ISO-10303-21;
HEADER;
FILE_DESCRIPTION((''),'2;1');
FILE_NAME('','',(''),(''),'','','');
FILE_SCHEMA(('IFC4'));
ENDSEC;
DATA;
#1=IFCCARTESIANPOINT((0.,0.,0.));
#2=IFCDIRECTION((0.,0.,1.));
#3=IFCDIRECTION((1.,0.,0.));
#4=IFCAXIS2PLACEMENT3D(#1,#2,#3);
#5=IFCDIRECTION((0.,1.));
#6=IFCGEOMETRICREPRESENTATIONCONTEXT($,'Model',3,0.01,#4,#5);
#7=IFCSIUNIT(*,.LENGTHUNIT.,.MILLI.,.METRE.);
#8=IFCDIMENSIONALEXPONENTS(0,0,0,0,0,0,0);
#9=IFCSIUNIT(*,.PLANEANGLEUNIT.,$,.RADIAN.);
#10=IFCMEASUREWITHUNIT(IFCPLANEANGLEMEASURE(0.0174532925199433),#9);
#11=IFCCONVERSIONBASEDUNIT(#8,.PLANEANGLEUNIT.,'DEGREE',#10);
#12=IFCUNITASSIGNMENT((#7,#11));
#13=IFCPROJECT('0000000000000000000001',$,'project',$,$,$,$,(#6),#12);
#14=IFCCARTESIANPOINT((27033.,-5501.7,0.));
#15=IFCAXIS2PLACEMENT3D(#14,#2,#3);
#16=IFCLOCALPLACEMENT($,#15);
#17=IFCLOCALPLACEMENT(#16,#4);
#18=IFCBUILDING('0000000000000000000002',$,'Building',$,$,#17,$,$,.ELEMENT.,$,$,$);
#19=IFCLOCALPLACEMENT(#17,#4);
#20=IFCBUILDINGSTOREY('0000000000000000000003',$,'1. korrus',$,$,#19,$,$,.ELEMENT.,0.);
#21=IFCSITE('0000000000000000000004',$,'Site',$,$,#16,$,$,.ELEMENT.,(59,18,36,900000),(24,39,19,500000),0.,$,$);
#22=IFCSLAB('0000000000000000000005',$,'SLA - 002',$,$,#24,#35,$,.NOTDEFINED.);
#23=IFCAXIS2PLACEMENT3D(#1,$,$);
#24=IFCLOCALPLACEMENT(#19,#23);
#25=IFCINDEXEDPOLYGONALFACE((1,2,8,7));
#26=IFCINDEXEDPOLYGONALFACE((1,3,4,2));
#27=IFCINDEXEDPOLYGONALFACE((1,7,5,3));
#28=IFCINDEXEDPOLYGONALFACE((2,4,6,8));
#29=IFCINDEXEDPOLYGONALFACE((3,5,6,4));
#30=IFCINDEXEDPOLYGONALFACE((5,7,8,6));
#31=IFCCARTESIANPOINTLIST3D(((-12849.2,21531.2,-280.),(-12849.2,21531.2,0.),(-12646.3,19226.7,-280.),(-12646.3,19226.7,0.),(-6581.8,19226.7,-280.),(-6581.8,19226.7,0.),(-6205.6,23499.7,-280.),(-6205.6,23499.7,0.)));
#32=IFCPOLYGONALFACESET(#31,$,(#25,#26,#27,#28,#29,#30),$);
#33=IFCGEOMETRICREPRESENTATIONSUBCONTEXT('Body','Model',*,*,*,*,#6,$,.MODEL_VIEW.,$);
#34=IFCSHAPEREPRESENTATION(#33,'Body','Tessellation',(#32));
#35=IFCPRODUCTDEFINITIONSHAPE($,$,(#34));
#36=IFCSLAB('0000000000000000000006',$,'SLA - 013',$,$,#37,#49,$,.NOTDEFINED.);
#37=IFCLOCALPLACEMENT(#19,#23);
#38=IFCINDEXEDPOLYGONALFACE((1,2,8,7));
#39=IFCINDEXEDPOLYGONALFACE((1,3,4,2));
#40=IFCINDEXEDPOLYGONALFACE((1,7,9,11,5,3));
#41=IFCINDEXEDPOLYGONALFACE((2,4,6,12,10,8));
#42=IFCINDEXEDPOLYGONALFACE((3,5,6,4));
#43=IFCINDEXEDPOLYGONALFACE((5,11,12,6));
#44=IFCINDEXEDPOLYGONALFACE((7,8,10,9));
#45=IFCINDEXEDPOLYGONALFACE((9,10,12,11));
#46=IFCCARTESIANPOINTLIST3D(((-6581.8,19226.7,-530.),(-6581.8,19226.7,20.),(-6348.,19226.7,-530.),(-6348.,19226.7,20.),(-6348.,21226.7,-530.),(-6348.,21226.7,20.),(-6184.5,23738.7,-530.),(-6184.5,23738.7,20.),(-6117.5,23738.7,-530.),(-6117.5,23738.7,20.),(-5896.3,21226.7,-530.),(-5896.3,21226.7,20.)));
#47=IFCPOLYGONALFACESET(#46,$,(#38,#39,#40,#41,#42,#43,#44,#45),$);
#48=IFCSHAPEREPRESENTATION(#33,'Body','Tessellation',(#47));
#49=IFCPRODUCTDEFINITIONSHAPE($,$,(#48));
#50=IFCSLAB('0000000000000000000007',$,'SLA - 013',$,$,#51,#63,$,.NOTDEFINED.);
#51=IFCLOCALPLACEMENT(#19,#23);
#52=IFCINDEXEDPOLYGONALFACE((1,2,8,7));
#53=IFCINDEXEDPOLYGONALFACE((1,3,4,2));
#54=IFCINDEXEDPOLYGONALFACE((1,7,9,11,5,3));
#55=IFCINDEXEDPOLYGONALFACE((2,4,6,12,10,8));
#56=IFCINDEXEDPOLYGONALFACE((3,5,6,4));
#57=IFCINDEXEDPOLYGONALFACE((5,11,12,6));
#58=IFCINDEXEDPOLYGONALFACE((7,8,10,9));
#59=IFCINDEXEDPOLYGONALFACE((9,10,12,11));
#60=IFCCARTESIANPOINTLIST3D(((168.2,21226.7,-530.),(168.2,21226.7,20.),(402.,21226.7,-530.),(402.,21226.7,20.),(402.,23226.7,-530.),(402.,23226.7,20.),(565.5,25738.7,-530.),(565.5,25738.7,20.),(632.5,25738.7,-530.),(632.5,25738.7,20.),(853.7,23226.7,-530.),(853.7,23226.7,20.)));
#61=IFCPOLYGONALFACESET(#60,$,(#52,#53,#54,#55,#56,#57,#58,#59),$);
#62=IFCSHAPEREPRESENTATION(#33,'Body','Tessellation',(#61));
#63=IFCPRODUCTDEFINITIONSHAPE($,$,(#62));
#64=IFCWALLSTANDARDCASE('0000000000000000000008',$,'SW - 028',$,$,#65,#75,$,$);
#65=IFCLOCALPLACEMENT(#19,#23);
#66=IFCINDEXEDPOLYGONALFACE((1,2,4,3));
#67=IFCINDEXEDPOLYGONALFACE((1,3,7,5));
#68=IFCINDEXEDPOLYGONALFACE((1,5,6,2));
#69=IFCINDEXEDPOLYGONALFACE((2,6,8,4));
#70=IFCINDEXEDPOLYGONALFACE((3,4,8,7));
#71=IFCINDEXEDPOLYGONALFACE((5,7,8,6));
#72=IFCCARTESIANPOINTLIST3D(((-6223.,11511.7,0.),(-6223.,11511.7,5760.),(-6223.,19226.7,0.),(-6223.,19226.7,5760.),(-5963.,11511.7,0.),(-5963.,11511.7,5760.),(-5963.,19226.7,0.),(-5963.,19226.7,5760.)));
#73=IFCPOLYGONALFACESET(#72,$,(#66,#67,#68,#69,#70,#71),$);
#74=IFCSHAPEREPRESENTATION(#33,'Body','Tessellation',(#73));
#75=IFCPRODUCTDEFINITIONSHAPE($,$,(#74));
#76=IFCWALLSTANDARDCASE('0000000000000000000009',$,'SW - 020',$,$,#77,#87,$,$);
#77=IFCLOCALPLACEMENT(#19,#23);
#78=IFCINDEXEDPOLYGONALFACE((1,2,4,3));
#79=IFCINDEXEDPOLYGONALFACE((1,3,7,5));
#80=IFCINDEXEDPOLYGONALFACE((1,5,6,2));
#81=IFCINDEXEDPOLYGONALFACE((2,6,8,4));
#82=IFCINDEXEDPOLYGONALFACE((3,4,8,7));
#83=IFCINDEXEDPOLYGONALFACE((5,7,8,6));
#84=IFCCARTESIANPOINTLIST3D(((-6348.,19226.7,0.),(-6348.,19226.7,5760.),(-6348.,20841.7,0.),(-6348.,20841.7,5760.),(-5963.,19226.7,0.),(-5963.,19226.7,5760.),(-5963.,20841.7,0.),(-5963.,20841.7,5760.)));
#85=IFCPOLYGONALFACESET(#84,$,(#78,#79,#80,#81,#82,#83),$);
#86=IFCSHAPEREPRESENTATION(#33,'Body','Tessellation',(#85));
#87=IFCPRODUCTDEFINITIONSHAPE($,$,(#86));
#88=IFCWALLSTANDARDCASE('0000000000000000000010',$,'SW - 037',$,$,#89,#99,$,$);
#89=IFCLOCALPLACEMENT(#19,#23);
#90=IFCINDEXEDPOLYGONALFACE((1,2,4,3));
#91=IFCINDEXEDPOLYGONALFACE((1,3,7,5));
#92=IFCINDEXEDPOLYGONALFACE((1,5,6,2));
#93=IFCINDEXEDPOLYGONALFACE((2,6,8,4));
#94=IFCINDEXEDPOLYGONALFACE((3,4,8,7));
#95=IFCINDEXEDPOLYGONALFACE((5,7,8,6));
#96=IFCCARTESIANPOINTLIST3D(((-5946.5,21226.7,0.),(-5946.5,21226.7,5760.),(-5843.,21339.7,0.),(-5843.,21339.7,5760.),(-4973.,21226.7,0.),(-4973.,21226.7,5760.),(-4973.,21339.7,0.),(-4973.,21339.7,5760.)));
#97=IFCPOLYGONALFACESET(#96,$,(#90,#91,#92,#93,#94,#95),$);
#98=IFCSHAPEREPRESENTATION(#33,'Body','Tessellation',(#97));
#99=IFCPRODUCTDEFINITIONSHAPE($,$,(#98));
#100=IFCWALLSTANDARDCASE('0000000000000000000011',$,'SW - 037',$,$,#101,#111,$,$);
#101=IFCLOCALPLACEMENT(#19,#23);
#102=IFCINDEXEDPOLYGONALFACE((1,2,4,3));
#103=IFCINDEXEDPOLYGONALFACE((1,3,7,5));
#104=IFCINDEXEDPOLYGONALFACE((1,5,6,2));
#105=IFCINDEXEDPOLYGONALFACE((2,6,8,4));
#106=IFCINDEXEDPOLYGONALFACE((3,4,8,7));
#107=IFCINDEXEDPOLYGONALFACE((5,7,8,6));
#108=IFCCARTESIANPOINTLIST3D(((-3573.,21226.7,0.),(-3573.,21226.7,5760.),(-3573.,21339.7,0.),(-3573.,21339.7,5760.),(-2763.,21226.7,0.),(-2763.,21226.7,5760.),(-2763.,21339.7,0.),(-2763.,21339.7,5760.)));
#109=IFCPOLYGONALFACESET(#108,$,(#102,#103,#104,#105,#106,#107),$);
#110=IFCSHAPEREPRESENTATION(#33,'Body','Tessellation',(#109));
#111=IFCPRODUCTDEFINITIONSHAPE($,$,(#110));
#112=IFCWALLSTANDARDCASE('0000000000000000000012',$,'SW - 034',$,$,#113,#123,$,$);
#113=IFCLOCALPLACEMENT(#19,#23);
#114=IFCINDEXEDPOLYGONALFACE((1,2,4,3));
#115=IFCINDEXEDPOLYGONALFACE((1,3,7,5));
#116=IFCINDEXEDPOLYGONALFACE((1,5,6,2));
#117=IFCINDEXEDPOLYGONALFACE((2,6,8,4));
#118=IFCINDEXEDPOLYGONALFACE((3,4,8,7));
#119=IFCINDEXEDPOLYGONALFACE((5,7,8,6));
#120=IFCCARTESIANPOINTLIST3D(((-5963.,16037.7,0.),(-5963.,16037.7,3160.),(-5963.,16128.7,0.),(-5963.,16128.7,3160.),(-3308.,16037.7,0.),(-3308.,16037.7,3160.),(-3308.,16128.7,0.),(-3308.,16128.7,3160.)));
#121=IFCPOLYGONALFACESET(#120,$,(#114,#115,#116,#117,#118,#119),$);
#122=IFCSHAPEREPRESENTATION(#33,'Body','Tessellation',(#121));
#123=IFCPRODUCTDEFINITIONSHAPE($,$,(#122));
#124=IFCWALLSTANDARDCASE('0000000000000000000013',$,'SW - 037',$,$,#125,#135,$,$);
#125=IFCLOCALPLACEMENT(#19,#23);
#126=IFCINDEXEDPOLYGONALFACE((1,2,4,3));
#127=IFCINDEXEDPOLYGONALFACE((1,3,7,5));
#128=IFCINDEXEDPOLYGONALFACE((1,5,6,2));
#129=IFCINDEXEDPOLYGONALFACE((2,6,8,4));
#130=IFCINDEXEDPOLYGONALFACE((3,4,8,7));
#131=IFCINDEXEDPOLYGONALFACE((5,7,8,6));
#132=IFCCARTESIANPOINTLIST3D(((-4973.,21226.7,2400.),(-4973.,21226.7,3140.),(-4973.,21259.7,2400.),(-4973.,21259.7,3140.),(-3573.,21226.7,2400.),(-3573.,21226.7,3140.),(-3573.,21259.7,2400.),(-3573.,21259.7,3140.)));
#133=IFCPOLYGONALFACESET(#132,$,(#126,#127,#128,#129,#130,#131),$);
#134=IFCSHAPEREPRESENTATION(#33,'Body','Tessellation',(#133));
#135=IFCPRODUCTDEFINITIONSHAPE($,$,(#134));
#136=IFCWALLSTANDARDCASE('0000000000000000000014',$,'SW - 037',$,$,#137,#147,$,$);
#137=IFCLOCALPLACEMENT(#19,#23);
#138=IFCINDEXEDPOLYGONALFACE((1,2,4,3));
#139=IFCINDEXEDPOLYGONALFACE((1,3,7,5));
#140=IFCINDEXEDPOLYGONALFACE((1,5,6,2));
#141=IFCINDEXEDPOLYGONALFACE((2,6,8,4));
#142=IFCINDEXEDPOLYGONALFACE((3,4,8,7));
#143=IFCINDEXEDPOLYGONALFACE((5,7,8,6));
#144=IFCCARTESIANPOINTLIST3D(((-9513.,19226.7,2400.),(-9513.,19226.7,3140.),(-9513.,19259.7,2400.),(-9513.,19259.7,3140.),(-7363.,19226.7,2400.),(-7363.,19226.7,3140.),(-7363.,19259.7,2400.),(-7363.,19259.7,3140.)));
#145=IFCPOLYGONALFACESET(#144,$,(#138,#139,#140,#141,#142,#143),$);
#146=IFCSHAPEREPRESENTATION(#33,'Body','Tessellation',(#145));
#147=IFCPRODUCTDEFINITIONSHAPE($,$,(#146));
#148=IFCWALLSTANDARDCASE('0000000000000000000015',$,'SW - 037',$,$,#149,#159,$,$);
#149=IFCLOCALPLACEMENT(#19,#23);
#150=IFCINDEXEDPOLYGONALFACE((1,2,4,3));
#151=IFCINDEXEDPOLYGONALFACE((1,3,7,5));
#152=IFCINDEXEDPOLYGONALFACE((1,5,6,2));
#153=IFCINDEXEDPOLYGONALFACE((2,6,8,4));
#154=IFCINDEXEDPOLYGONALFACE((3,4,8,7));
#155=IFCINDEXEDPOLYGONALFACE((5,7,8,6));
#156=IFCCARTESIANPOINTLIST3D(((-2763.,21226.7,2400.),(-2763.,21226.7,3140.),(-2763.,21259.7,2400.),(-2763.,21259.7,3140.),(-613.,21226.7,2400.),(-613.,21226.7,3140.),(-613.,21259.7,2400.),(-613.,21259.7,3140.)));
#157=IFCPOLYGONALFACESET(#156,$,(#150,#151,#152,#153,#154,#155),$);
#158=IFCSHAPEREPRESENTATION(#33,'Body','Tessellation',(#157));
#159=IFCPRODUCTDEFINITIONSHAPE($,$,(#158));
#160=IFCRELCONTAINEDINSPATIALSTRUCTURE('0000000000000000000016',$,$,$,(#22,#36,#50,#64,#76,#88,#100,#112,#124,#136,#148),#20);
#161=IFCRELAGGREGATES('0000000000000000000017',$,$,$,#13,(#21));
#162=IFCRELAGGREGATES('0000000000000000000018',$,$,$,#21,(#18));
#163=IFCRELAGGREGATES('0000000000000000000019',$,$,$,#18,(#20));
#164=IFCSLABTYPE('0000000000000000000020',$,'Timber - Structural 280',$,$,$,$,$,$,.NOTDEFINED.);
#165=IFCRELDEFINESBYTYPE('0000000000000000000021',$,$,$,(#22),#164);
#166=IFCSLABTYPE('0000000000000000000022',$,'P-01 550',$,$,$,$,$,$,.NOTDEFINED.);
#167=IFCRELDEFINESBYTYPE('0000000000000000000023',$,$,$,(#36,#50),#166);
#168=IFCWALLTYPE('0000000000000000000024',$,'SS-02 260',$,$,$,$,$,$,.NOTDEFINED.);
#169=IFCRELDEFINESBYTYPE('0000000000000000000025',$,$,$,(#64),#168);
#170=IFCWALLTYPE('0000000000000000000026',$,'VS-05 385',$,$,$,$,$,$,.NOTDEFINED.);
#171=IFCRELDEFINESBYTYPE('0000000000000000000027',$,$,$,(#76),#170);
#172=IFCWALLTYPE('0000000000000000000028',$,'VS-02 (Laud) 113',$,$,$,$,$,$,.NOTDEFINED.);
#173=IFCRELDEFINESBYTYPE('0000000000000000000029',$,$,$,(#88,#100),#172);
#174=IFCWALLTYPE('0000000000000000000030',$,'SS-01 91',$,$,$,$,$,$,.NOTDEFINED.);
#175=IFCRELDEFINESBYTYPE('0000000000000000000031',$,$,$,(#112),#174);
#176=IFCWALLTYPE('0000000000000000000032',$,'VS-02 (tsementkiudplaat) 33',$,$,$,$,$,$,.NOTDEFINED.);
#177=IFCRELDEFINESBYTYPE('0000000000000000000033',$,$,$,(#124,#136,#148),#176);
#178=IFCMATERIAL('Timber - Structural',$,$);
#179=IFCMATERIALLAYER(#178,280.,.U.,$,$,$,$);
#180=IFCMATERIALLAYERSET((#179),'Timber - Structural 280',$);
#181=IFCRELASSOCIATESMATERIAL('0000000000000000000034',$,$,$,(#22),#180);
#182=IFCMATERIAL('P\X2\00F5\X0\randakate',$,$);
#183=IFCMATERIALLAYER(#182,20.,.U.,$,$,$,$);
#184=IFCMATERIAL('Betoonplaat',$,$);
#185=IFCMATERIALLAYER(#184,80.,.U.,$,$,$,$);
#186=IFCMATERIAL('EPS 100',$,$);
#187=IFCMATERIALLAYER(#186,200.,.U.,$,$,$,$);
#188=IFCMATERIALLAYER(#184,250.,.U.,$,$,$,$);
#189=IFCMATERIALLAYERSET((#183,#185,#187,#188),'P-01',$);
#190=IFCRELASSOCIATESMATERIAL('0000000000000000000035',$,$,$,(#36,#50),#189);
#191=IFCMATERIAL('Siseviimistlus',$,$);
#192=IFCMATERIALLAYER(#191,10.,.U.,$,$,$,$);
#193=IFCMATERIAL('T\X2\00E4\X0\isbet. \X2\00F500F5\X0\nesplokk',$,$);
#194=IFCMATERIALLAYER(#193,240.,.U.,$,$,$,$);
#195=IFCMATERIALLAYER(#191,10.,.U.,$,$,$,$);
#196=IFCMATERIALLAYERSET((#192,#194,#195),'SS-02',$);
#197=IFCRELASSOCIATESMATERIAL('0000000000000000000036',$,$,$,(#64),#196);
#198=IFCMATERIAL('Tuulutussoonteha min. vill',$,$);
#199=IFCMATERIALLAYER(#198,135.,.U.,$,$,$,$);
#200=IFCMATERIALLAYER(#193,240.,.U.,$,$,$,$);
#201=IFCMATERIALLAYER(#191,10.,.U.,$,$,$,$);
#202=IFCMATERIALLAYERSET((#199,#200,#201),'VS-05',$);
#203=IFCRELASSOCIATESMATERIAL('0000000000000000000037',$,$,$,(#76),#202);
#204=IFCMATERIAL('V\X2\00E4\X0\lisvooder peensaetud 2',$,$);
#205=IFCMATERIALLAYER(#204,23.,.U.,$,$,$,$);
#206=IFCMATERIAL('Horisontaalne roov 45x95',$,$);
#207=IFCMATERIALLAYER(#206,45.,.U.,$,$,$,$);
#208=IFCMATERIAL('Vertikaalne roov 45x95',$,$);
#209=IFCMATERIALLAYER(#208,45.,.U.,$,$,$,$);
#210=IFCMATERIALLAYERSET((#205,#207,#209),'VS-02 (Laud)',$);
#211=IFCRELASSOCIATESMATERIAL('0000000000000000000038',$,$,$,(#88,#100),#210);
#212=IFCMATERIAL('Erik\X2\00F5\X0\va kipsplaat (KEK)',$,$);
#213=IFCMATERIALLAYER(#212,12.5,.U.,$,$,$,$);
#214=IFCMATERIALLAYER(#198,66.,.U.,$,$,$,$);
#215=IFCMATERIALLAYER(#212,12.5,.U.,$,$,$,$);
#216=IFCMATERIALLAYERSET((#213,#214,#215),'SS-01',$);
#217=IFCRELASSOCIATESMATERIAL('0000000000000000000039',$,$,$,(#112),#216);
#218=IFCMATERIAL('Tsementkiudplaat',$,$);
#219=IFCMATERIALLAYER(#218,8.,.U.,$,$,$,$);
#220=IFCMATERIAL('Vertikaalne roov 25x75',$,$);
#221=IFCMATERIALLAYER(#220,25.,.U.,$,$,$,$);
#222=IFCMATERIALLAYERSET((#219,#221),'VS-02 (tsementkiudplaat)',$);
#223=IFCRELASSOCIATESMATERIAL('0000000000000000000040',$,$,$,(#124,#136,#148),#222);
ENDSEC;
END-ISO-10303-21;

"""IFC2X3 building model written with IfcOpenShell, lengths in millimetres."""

from ifc_helpers import new_model, entity, si_unit, converted_unit, direction, frame, origin_with_axes, place, context, subcontext, project, spatial, polyline, outline, extrude, material, layer, layer_set, layer_usage, type_object, element, save


model = new_model("IFC2X3")

# Units and contexts
model_context = context("Model", 3, precision=0.01, world=origin_with_axes(), true_north=direction((0.0, 1.0)))
body_context = subcontext(model_context, "Body", "Model", "MODEL_VIEW")
ifc_project = project(units=[si_unit("LENGTHUNIT", "METRE", prefix="MILLI"), converted_unit("PLANEANGLEUNIT", "DEGREE", entity("IfcPlaneAngleMeasure", 0.0174532925199433), si_unit("PLANEANGLEUNIT", "RADIAN"), dimensions=[0, 0, 0, 0, 0, 0, 0])], contexts=[model_context])

# Site, building, storey
site_placement = place(None, frame((27033.0, -5501.7, 0.0), z_axis=(0.0, 0.0, 1.0), x_axis=(1.0, 0.0, 0.0)))
site = spatial("IfcSite", under=ifc_project, at=site_placement, Name="Site", CompositionType="ELEMENT", RefLatitude=(59, 18, 36, 900000), RefLongitude=(24, 39, 19, 500000), RefElevation=0.0)
building_placement = place(site_placement, origin_with_axes())
building = spatial("IfcBuilding", under=site, at=building_placement, Name="Building", CompositionType="ELEMENT")
storey_placement = place(building_placement, origin_with_axes())
storey = spatial("IfcBuildingStorey", under=building, at=storey_placement, Name="1. korrus", CompositionType="ELEMENT", Elevation=0.0)

# Slabs
ifc_material_1 = material(Name="Timber - Structural")
ifc_layer_1 = layer(ifc_material_1, 280.0, ventilated="UNKNOWN")
ifc_layer_set_1 = layer_set([ifc_layer_1], Name="Timber - Structural 280")
ifc_layer_usage_1 = layer_usage(ifc_layer_set_1, "AXIS3", "NEGATIVE", 280.0)
slab_type_1 = type_object("IfcSlabType", Name="Timber - Structural 280", PredefinedType="NOTDEFINED")
slab_1_placement = place(storey_placement, frame((-6205.6, 23499.7, 0.0), z_axis=(0.0, 0.0, 1.0), x_axis=(1.0, 0.0, 0.0)))
element("IfcSlab", 1, at=slab_1_placement, inside=storey, type_object=slab_type_1, material=ifc_layer_usage_1, Name="SLA - 002", PredefinedType="NOTDEFINED", context=body_context, shape_type="SweptSolid", body=[
    extrude(outline(polyline([(0.0, 0.0), (-6643.7, -1968.5), (-6440.8, -4273.0), (-376.2, -4273.0), (0.0, 0.0)])), frame((0.0, 0.0, -280.0), z_axis=(0.0, 0.0, 1.0), x_axis=(1.0, 0.0, 0.0)), (0.0, 0.0, 1.0), 280.0),
])
ifc_material_2 = material(Name="Põrandakate")
ifc_layer_2 = layer(ifc_material_2, 20.0, ventilated="UNKNOWN")
ifc_material_3 = material(Name="Betoonplaat")
ifc_layer_3 = layer(ifc_material_3, 80.0, ventilated="UNKNOWN")
ifc_material_4 = material(Name="EPS 100")
ifc_layer_4 = layer(ifc_material_4, 200.0, ventilated="UNKNOWN")
ifc_layer_5 = layer(ifc_material_3, 250.0, ventilated="UNKNOWN")
ifc_layer_set_2 = layer_set([ifc_layer_2, ifc_layer_3, ifc_layer_4, ifc_layer_5], Name="P-01")
ifc_layer_usage_2 = layer_usage(ifc_layer_set_2, "AXIS3", "NEGATIVE", 550.0)
slab_type_2 = type_object("IfcSlabType", Name="P-01 550", PredefinedType="NOTDEFINED")
slab_2_placement = place(storey_placement, frame((-6581.8, 19226.7, 0.0), z_axis=(0.0, 0.0, 1.0), x_axis=(1.0, 0.0, 0.0)))
element("IfcSlab", 2, at=slab_2_placement, inside=storey, type_object=slab_type_2, material=ifc_layer_usage_2, Name="SLA - 013", PredefinedType="NOTDEFINED", context=body_context, shape_type="SweptSolid", body=[
    extrude(outline(polyline([(0.0, 0.0), (233.8, 0.0), (233.8, 2000.0), (685.5, 2000.0), (464.3, 4512.0), (397.3, 4512.0), (0.0, 0.0)])), frame((0.0, 0.0, -530.0), z_axis=(0.0, 0.0, 1.0), x_axis=(1.0, 0.0, 0.0)), (0.0, 0.0, 1.0), 550.0),
])
ifc_layer_usage_3 = layer_usage(ifc_layer_set_2, "AXIS3", "NEGATIVE", 550.0)
slab_3_placement = place(storey_placement, frame((168.2, 21226.7, 0.0), z_axis=(0.0, 0.0, 1.0), x_axis=(1.0, 0.0, 0.0)))
element("IfcSlab", 3, at=slab_3_placement, inside=storey, type_object=slab_type_2, material=ifc_layer_usage_3, Name="SLA - 013", PredefinedType="NOTDEFINED", context=body_context, shape_type="SweptSolid", body=[
    extrude(outline(polyline([(0.0, 0.0), (233.8, 0.0), (233.8, 2000.0), (685.5, 2000.0), (464.3, 4512.0), (397.3, 4512.0), (0.0, 0.0)])), frame((0.0, 0.0, -530.0), z_axis=(0.0, 0.0, 1.0), x_axis=(1.0, 0.0, 0.0)), (0.0, 0.0, 1.0), 550.0),
])

# Wall
ifc_material_5 = material(Name="Siseviimistlus")
ifc_layer_6 = layer(ifc_material_5, 10.0, ventilated="UNKNOWN")
ifc_material_6 = material(Name="Täisbet. õõnesplokk")
ifc_layer_7 = layer(ifc_material_6, 240.0, ventilated="UNKNOWN")
ifc_layer_8 = layer(ifc_material_5, 10.0, ventilated="UNKNOWN")
ifc_layer_set_3 = layer_set([ifc_layer_6, ifc_layer_7, ifc_layer_8], Name="SS-02")
ifc_layer_usage_4 = layer_usage(ifc_layer_set_3, "AXIS2", "POSITIVE", -260.0)
wall_type_1 = type_object("IfcWallType", Name="SS-02 260", PredefinedType="NOTDEFINED")
wall_1_placement = place(storey_placement, frame((-5963.0, 19226.7, 0.0), z_axis=(0.0, 0.0, 1.0), x_axis=(0.0, -1.0, 0.0)))
element("IfcWallStandardCase", 4, at=wall_1_placement, inside=storey, type_object=wall_type_1, material=ifc_layer_usage_4, Name="SW - 028", context=body_context, shape_type="SweptSolid", body=[
    extrude(outline(polyline([(0.0, -260.0), (7715.0, -260.0), (7715.0, 0.0), (0.0, 0.0), (0.0, -260.0)])), origin_with_axes(), (0.0, 0.0, 1.0), 5760.0),
])

# Walls
ifc_material_7 = material(Name="Tuulutussoonteha min. vill")
ifc_layer_9 = layer(ifc_material_7, 135.0, ventilated="UNKNOWN")
ifc_layer_10 = layer(ifc_material_6, 240.0, ventilated="UNKNOWN")
ifc_layer_11 = layer(ifc_material_5, 10.0, ventilated="UNKNOWN")
ifc_layer_set_4 = layer_set([ifc_layer_9, ifc_layer_10, ifc_layer_11], Name="VS-05")
ifc_layer_usage_5 = layer_usage(ifc_layer_set_4, "AXIS2", "POSITIVE", -385.0)
wall_type_2 = type_object("IfcWallType", Name="VS-05 385", PredefinedType="NOTDEFINED")
wall_2_placement = place(storey_placement, frame((-5963.0, 21226.7, 0.0), z_axis=(0.0, 0.0, 1.0), x_axis=(0.0, -1.0, 0.0)))
element("IfcWallStandardCase", 5, at=wall_2_placement, inside=storey, type_object=wall_type_2, material=ifc_layer_usage_5, Name="SW - 020", context=body_context, shape_type="SweptSolid", body=[
    extrude(outline(polyline([(385.0, -385.0), (2000.0, -385.0), (2000.0, 0.0), (385.0, 0.0), (385.0, -385.0)])), origin_with_axes(), (0.0, 0.0, 1.0), 5760.0),
])
ifc_material_8 = material(Name="Välisvooder peensaetud 2")
ifc_layer_12 = layer(ifc_material_8, 23.0, ventilated="UNKNOWN")
ifc_material_9 = material(Name="Horisontaalne roov 45x95")
ifc_layer_13 = layer(ifc_material_9, 45.0, ventilated="UNKNOWN")
ifc_material_10 = material(Name="Vertikaalne roov 45x95")
ifc_layer_14 = layer(ifc_material_10, 45.0, ventilated="UNKNOWN")
ifc_layer_set_5 = layer_set([ifc_layer_12, ifc_layer_13, ifc_layer_14], Name="VS-02 (Laud)")
ifc_layer_usage_6 = layer_usage(ifc_layer_set_5, "AXIS2", "POSITIVE", -113.0)
wall_type_3 = type_object("IfcWallType", Name="VS-02 (Laud) 113", PredefinedType="NOTDEFINED")
wall_3_placement = place(storey_placement, frame((-4973.0, 21226.7, 0.0), z_axis=(0.0, 0.0, 1.0), x_axis=(-1.0, 0.0, 0.0)))
element("IfcWallStandardCase", 6, at=wall_3_placement, inside=storey, type_object=wall_type_3, material=ifc_layer_usage_6, Name="SW - 037", context=body_context, shape_type="SweptSolid", body=[
    extrude(outline(polyline([(0.0, -113.0), (870.0, -113.0), (973.5, 0.0), (0.0, 0.0), (0.0, -113.0)])), origin_with_axes(), (0.0, 0.0, 1.0), 5760.0),
])
ifc_layer_usage_7 = layer_usage(ifc_layer_set_5, "AXIS2", "POSITIVE", -113.0)
wall_4_placement = place(storey_placement, frame((-2763.0, 21226.7, 0.0), z_axis=(0.0, 0.0, 1.0), x_axis=(-1.0, 0.0, 0.0)))
element("IfcWallStandardCase", 7, at=wall_4_placement, inside=storey, type_object=wall_type_3, material=ifc_layer_usage_7, Name="SW - 037", context=body_context, shape_type="SweptSolid", body=[
    extrude(outline(polyline([(0.0, -113.0), (810.0, -113.0), (810.0, 0.0), (0.0, 0.0), (0.0, -113.0)])), origin_with_axes(), (0.0, 0.0, 1.0), 5760.0),
])
ifc_material_11 = material(Name="Erikõva kipsplaat (KEK)")
ifc_layer_15 = layer(ifc_material_11, 12.5, ventilated="UNKNOWN")
ifc_layer_16 = layer(ifc_material_7, 66.0, ventilated="UNKNOWN")
ifc_layer_17 = layer(ifc_material_11, 12.5, ventilated="UNKNOWN")
ifc_layer_set_6 = layer_set([ifc_layer_15, ifc_layer_16, ifc_layer_17], Name="SS-01")
ifc_layer_usage_8 = layer_usage(ifc_layer_set_6, "AXIS2", "NEGATIVE", 91.0)
wall_type_4 = type_object("IfcWallType", Name="SS-01 91", PredefinedType="NOTDEFINED")
wall_5_placement = place(storey_placement, frame((-5963.0, 16037.7, 0.0), z_axis=(0.0, 0.0, 1.0), x_axis=(1.0, 0.0, 0.0)))
element("IfcWallStandardCase", 8, at=wall_5_placement, inside=storey, type_object=wall_type_4, material=ifc_layer_usage_8, Name="SW - 034", context=body_context, shape_type="SweptSolid", body=[
    extrude(outline(polyline([(0.0, 0.0), (2655.0, 0.0), (2655.0, 91.0), (0.0, 91.0), (0.0, 0.0)])), origin_with_axes(), (0.0, 0.0, 1.0), 3160.0),
])
ifc_material_12 = material(Name="Tsementkiudplaat")
ifc_layer_18 = layer(ifc_material_12, 8.0, ventilated="UNKNOWN")
ifc_material_13 = material(Name="Vertikaalne roov 25x75")
ifc_layer_19 = layer(ifc_material_13, 25.0, ventilated="UNKNOWN")
ifc_layer_set_7 = layer_set([ifc_layer_18, ifc_layer_19], Name="VS-02 (tsementkiudplaat)")
ifc_layer_usage_9 = layer_usage(ifc_layer_set_7, "AXIS2", "POSITIVE", -33.0)
wall_type_5 = type_object("IfcWallType", Name="VS-02 (tsementkiudplaat) 33", PredefinedType="NOTDEFINED")
wall_6_placement = place(storey_placement, frame((-3573.0, 21226.7, 2400.0), z_axis=(0.0, 0.0, 1.0), x_axis=(-1.0, 0.0, 0.0)))
element("IfcWallStandardCase", 9, at=wall_6_placement, inside=storey, type_object=wall_type_5, material=ifc_layer_usage_9, Name="SW - 037", context=body_context, shape_type="SweptSolid", body=[
    extrude(outline(polyline([(0.0, -33.0), (1400.0, -33.0), (1400.0, 0.0), (0.0, 0.0), (0.0, -33.0)])), origin_with_axes(), (0.0, 0.0, 1.0), 740.0),
])
ifc_layer_usage_10 = layer_usage(ifc_layer_set_7, "AXIS2", "POSITIVE", -33.0)
wall_7_placement = place(storey_placement, frame((-7363.0, 19226.7, 2400.0), z_axis=(0.0, 0.0, 1.0), x_axis=(-1.0, 0.0, 0.0)))
element("IfcWallStandardCase", 10, at=wall_7_placement, inside=storey, type_object=wall_type_5, material=ifc_layer_usage_10, Name="SW - 037", context=body_context, shape_type="SweptSolid", body=[
    extrude(outline(polyline([(0.0, -33.0), (2150.0, -33.0), (2150.0, 0.0), (0.0, 0.0), (0.0, -33.0)])), origin_with_axes(), (0.0, 0.0, 1.0), 740.0),
])
ifc_layer_usage_11 = layer_usage(ifc_layer_set_7, "AXIS2", "POSITIVE", -33.0)
wall_8_placement = place(storey_placement, frame((-613.0, 21226.7, 2400.0), z_axis=(0.0, 0.0, 1.0), x_axis=(-1.0, 0.0, 0.0)))
element("IfcWallStandardCase", 11, at=wall_8_placement, inside=storey, type_object=wall_type_5, material=ifc_layer_usage_11, Name="SW - 037", context=body_context, shape_type="SweptSolid", body=[
    extrude(outline(polyline([(0.0, -33.0), (2150.0, -33.0), (2150.0, 0.0), (0.0, 0.0), (0.0, -33.0)])), origin_with_axes(), (0.0, 0.0, 1.0), 740.0),
])

save(model, "model.ifc")
